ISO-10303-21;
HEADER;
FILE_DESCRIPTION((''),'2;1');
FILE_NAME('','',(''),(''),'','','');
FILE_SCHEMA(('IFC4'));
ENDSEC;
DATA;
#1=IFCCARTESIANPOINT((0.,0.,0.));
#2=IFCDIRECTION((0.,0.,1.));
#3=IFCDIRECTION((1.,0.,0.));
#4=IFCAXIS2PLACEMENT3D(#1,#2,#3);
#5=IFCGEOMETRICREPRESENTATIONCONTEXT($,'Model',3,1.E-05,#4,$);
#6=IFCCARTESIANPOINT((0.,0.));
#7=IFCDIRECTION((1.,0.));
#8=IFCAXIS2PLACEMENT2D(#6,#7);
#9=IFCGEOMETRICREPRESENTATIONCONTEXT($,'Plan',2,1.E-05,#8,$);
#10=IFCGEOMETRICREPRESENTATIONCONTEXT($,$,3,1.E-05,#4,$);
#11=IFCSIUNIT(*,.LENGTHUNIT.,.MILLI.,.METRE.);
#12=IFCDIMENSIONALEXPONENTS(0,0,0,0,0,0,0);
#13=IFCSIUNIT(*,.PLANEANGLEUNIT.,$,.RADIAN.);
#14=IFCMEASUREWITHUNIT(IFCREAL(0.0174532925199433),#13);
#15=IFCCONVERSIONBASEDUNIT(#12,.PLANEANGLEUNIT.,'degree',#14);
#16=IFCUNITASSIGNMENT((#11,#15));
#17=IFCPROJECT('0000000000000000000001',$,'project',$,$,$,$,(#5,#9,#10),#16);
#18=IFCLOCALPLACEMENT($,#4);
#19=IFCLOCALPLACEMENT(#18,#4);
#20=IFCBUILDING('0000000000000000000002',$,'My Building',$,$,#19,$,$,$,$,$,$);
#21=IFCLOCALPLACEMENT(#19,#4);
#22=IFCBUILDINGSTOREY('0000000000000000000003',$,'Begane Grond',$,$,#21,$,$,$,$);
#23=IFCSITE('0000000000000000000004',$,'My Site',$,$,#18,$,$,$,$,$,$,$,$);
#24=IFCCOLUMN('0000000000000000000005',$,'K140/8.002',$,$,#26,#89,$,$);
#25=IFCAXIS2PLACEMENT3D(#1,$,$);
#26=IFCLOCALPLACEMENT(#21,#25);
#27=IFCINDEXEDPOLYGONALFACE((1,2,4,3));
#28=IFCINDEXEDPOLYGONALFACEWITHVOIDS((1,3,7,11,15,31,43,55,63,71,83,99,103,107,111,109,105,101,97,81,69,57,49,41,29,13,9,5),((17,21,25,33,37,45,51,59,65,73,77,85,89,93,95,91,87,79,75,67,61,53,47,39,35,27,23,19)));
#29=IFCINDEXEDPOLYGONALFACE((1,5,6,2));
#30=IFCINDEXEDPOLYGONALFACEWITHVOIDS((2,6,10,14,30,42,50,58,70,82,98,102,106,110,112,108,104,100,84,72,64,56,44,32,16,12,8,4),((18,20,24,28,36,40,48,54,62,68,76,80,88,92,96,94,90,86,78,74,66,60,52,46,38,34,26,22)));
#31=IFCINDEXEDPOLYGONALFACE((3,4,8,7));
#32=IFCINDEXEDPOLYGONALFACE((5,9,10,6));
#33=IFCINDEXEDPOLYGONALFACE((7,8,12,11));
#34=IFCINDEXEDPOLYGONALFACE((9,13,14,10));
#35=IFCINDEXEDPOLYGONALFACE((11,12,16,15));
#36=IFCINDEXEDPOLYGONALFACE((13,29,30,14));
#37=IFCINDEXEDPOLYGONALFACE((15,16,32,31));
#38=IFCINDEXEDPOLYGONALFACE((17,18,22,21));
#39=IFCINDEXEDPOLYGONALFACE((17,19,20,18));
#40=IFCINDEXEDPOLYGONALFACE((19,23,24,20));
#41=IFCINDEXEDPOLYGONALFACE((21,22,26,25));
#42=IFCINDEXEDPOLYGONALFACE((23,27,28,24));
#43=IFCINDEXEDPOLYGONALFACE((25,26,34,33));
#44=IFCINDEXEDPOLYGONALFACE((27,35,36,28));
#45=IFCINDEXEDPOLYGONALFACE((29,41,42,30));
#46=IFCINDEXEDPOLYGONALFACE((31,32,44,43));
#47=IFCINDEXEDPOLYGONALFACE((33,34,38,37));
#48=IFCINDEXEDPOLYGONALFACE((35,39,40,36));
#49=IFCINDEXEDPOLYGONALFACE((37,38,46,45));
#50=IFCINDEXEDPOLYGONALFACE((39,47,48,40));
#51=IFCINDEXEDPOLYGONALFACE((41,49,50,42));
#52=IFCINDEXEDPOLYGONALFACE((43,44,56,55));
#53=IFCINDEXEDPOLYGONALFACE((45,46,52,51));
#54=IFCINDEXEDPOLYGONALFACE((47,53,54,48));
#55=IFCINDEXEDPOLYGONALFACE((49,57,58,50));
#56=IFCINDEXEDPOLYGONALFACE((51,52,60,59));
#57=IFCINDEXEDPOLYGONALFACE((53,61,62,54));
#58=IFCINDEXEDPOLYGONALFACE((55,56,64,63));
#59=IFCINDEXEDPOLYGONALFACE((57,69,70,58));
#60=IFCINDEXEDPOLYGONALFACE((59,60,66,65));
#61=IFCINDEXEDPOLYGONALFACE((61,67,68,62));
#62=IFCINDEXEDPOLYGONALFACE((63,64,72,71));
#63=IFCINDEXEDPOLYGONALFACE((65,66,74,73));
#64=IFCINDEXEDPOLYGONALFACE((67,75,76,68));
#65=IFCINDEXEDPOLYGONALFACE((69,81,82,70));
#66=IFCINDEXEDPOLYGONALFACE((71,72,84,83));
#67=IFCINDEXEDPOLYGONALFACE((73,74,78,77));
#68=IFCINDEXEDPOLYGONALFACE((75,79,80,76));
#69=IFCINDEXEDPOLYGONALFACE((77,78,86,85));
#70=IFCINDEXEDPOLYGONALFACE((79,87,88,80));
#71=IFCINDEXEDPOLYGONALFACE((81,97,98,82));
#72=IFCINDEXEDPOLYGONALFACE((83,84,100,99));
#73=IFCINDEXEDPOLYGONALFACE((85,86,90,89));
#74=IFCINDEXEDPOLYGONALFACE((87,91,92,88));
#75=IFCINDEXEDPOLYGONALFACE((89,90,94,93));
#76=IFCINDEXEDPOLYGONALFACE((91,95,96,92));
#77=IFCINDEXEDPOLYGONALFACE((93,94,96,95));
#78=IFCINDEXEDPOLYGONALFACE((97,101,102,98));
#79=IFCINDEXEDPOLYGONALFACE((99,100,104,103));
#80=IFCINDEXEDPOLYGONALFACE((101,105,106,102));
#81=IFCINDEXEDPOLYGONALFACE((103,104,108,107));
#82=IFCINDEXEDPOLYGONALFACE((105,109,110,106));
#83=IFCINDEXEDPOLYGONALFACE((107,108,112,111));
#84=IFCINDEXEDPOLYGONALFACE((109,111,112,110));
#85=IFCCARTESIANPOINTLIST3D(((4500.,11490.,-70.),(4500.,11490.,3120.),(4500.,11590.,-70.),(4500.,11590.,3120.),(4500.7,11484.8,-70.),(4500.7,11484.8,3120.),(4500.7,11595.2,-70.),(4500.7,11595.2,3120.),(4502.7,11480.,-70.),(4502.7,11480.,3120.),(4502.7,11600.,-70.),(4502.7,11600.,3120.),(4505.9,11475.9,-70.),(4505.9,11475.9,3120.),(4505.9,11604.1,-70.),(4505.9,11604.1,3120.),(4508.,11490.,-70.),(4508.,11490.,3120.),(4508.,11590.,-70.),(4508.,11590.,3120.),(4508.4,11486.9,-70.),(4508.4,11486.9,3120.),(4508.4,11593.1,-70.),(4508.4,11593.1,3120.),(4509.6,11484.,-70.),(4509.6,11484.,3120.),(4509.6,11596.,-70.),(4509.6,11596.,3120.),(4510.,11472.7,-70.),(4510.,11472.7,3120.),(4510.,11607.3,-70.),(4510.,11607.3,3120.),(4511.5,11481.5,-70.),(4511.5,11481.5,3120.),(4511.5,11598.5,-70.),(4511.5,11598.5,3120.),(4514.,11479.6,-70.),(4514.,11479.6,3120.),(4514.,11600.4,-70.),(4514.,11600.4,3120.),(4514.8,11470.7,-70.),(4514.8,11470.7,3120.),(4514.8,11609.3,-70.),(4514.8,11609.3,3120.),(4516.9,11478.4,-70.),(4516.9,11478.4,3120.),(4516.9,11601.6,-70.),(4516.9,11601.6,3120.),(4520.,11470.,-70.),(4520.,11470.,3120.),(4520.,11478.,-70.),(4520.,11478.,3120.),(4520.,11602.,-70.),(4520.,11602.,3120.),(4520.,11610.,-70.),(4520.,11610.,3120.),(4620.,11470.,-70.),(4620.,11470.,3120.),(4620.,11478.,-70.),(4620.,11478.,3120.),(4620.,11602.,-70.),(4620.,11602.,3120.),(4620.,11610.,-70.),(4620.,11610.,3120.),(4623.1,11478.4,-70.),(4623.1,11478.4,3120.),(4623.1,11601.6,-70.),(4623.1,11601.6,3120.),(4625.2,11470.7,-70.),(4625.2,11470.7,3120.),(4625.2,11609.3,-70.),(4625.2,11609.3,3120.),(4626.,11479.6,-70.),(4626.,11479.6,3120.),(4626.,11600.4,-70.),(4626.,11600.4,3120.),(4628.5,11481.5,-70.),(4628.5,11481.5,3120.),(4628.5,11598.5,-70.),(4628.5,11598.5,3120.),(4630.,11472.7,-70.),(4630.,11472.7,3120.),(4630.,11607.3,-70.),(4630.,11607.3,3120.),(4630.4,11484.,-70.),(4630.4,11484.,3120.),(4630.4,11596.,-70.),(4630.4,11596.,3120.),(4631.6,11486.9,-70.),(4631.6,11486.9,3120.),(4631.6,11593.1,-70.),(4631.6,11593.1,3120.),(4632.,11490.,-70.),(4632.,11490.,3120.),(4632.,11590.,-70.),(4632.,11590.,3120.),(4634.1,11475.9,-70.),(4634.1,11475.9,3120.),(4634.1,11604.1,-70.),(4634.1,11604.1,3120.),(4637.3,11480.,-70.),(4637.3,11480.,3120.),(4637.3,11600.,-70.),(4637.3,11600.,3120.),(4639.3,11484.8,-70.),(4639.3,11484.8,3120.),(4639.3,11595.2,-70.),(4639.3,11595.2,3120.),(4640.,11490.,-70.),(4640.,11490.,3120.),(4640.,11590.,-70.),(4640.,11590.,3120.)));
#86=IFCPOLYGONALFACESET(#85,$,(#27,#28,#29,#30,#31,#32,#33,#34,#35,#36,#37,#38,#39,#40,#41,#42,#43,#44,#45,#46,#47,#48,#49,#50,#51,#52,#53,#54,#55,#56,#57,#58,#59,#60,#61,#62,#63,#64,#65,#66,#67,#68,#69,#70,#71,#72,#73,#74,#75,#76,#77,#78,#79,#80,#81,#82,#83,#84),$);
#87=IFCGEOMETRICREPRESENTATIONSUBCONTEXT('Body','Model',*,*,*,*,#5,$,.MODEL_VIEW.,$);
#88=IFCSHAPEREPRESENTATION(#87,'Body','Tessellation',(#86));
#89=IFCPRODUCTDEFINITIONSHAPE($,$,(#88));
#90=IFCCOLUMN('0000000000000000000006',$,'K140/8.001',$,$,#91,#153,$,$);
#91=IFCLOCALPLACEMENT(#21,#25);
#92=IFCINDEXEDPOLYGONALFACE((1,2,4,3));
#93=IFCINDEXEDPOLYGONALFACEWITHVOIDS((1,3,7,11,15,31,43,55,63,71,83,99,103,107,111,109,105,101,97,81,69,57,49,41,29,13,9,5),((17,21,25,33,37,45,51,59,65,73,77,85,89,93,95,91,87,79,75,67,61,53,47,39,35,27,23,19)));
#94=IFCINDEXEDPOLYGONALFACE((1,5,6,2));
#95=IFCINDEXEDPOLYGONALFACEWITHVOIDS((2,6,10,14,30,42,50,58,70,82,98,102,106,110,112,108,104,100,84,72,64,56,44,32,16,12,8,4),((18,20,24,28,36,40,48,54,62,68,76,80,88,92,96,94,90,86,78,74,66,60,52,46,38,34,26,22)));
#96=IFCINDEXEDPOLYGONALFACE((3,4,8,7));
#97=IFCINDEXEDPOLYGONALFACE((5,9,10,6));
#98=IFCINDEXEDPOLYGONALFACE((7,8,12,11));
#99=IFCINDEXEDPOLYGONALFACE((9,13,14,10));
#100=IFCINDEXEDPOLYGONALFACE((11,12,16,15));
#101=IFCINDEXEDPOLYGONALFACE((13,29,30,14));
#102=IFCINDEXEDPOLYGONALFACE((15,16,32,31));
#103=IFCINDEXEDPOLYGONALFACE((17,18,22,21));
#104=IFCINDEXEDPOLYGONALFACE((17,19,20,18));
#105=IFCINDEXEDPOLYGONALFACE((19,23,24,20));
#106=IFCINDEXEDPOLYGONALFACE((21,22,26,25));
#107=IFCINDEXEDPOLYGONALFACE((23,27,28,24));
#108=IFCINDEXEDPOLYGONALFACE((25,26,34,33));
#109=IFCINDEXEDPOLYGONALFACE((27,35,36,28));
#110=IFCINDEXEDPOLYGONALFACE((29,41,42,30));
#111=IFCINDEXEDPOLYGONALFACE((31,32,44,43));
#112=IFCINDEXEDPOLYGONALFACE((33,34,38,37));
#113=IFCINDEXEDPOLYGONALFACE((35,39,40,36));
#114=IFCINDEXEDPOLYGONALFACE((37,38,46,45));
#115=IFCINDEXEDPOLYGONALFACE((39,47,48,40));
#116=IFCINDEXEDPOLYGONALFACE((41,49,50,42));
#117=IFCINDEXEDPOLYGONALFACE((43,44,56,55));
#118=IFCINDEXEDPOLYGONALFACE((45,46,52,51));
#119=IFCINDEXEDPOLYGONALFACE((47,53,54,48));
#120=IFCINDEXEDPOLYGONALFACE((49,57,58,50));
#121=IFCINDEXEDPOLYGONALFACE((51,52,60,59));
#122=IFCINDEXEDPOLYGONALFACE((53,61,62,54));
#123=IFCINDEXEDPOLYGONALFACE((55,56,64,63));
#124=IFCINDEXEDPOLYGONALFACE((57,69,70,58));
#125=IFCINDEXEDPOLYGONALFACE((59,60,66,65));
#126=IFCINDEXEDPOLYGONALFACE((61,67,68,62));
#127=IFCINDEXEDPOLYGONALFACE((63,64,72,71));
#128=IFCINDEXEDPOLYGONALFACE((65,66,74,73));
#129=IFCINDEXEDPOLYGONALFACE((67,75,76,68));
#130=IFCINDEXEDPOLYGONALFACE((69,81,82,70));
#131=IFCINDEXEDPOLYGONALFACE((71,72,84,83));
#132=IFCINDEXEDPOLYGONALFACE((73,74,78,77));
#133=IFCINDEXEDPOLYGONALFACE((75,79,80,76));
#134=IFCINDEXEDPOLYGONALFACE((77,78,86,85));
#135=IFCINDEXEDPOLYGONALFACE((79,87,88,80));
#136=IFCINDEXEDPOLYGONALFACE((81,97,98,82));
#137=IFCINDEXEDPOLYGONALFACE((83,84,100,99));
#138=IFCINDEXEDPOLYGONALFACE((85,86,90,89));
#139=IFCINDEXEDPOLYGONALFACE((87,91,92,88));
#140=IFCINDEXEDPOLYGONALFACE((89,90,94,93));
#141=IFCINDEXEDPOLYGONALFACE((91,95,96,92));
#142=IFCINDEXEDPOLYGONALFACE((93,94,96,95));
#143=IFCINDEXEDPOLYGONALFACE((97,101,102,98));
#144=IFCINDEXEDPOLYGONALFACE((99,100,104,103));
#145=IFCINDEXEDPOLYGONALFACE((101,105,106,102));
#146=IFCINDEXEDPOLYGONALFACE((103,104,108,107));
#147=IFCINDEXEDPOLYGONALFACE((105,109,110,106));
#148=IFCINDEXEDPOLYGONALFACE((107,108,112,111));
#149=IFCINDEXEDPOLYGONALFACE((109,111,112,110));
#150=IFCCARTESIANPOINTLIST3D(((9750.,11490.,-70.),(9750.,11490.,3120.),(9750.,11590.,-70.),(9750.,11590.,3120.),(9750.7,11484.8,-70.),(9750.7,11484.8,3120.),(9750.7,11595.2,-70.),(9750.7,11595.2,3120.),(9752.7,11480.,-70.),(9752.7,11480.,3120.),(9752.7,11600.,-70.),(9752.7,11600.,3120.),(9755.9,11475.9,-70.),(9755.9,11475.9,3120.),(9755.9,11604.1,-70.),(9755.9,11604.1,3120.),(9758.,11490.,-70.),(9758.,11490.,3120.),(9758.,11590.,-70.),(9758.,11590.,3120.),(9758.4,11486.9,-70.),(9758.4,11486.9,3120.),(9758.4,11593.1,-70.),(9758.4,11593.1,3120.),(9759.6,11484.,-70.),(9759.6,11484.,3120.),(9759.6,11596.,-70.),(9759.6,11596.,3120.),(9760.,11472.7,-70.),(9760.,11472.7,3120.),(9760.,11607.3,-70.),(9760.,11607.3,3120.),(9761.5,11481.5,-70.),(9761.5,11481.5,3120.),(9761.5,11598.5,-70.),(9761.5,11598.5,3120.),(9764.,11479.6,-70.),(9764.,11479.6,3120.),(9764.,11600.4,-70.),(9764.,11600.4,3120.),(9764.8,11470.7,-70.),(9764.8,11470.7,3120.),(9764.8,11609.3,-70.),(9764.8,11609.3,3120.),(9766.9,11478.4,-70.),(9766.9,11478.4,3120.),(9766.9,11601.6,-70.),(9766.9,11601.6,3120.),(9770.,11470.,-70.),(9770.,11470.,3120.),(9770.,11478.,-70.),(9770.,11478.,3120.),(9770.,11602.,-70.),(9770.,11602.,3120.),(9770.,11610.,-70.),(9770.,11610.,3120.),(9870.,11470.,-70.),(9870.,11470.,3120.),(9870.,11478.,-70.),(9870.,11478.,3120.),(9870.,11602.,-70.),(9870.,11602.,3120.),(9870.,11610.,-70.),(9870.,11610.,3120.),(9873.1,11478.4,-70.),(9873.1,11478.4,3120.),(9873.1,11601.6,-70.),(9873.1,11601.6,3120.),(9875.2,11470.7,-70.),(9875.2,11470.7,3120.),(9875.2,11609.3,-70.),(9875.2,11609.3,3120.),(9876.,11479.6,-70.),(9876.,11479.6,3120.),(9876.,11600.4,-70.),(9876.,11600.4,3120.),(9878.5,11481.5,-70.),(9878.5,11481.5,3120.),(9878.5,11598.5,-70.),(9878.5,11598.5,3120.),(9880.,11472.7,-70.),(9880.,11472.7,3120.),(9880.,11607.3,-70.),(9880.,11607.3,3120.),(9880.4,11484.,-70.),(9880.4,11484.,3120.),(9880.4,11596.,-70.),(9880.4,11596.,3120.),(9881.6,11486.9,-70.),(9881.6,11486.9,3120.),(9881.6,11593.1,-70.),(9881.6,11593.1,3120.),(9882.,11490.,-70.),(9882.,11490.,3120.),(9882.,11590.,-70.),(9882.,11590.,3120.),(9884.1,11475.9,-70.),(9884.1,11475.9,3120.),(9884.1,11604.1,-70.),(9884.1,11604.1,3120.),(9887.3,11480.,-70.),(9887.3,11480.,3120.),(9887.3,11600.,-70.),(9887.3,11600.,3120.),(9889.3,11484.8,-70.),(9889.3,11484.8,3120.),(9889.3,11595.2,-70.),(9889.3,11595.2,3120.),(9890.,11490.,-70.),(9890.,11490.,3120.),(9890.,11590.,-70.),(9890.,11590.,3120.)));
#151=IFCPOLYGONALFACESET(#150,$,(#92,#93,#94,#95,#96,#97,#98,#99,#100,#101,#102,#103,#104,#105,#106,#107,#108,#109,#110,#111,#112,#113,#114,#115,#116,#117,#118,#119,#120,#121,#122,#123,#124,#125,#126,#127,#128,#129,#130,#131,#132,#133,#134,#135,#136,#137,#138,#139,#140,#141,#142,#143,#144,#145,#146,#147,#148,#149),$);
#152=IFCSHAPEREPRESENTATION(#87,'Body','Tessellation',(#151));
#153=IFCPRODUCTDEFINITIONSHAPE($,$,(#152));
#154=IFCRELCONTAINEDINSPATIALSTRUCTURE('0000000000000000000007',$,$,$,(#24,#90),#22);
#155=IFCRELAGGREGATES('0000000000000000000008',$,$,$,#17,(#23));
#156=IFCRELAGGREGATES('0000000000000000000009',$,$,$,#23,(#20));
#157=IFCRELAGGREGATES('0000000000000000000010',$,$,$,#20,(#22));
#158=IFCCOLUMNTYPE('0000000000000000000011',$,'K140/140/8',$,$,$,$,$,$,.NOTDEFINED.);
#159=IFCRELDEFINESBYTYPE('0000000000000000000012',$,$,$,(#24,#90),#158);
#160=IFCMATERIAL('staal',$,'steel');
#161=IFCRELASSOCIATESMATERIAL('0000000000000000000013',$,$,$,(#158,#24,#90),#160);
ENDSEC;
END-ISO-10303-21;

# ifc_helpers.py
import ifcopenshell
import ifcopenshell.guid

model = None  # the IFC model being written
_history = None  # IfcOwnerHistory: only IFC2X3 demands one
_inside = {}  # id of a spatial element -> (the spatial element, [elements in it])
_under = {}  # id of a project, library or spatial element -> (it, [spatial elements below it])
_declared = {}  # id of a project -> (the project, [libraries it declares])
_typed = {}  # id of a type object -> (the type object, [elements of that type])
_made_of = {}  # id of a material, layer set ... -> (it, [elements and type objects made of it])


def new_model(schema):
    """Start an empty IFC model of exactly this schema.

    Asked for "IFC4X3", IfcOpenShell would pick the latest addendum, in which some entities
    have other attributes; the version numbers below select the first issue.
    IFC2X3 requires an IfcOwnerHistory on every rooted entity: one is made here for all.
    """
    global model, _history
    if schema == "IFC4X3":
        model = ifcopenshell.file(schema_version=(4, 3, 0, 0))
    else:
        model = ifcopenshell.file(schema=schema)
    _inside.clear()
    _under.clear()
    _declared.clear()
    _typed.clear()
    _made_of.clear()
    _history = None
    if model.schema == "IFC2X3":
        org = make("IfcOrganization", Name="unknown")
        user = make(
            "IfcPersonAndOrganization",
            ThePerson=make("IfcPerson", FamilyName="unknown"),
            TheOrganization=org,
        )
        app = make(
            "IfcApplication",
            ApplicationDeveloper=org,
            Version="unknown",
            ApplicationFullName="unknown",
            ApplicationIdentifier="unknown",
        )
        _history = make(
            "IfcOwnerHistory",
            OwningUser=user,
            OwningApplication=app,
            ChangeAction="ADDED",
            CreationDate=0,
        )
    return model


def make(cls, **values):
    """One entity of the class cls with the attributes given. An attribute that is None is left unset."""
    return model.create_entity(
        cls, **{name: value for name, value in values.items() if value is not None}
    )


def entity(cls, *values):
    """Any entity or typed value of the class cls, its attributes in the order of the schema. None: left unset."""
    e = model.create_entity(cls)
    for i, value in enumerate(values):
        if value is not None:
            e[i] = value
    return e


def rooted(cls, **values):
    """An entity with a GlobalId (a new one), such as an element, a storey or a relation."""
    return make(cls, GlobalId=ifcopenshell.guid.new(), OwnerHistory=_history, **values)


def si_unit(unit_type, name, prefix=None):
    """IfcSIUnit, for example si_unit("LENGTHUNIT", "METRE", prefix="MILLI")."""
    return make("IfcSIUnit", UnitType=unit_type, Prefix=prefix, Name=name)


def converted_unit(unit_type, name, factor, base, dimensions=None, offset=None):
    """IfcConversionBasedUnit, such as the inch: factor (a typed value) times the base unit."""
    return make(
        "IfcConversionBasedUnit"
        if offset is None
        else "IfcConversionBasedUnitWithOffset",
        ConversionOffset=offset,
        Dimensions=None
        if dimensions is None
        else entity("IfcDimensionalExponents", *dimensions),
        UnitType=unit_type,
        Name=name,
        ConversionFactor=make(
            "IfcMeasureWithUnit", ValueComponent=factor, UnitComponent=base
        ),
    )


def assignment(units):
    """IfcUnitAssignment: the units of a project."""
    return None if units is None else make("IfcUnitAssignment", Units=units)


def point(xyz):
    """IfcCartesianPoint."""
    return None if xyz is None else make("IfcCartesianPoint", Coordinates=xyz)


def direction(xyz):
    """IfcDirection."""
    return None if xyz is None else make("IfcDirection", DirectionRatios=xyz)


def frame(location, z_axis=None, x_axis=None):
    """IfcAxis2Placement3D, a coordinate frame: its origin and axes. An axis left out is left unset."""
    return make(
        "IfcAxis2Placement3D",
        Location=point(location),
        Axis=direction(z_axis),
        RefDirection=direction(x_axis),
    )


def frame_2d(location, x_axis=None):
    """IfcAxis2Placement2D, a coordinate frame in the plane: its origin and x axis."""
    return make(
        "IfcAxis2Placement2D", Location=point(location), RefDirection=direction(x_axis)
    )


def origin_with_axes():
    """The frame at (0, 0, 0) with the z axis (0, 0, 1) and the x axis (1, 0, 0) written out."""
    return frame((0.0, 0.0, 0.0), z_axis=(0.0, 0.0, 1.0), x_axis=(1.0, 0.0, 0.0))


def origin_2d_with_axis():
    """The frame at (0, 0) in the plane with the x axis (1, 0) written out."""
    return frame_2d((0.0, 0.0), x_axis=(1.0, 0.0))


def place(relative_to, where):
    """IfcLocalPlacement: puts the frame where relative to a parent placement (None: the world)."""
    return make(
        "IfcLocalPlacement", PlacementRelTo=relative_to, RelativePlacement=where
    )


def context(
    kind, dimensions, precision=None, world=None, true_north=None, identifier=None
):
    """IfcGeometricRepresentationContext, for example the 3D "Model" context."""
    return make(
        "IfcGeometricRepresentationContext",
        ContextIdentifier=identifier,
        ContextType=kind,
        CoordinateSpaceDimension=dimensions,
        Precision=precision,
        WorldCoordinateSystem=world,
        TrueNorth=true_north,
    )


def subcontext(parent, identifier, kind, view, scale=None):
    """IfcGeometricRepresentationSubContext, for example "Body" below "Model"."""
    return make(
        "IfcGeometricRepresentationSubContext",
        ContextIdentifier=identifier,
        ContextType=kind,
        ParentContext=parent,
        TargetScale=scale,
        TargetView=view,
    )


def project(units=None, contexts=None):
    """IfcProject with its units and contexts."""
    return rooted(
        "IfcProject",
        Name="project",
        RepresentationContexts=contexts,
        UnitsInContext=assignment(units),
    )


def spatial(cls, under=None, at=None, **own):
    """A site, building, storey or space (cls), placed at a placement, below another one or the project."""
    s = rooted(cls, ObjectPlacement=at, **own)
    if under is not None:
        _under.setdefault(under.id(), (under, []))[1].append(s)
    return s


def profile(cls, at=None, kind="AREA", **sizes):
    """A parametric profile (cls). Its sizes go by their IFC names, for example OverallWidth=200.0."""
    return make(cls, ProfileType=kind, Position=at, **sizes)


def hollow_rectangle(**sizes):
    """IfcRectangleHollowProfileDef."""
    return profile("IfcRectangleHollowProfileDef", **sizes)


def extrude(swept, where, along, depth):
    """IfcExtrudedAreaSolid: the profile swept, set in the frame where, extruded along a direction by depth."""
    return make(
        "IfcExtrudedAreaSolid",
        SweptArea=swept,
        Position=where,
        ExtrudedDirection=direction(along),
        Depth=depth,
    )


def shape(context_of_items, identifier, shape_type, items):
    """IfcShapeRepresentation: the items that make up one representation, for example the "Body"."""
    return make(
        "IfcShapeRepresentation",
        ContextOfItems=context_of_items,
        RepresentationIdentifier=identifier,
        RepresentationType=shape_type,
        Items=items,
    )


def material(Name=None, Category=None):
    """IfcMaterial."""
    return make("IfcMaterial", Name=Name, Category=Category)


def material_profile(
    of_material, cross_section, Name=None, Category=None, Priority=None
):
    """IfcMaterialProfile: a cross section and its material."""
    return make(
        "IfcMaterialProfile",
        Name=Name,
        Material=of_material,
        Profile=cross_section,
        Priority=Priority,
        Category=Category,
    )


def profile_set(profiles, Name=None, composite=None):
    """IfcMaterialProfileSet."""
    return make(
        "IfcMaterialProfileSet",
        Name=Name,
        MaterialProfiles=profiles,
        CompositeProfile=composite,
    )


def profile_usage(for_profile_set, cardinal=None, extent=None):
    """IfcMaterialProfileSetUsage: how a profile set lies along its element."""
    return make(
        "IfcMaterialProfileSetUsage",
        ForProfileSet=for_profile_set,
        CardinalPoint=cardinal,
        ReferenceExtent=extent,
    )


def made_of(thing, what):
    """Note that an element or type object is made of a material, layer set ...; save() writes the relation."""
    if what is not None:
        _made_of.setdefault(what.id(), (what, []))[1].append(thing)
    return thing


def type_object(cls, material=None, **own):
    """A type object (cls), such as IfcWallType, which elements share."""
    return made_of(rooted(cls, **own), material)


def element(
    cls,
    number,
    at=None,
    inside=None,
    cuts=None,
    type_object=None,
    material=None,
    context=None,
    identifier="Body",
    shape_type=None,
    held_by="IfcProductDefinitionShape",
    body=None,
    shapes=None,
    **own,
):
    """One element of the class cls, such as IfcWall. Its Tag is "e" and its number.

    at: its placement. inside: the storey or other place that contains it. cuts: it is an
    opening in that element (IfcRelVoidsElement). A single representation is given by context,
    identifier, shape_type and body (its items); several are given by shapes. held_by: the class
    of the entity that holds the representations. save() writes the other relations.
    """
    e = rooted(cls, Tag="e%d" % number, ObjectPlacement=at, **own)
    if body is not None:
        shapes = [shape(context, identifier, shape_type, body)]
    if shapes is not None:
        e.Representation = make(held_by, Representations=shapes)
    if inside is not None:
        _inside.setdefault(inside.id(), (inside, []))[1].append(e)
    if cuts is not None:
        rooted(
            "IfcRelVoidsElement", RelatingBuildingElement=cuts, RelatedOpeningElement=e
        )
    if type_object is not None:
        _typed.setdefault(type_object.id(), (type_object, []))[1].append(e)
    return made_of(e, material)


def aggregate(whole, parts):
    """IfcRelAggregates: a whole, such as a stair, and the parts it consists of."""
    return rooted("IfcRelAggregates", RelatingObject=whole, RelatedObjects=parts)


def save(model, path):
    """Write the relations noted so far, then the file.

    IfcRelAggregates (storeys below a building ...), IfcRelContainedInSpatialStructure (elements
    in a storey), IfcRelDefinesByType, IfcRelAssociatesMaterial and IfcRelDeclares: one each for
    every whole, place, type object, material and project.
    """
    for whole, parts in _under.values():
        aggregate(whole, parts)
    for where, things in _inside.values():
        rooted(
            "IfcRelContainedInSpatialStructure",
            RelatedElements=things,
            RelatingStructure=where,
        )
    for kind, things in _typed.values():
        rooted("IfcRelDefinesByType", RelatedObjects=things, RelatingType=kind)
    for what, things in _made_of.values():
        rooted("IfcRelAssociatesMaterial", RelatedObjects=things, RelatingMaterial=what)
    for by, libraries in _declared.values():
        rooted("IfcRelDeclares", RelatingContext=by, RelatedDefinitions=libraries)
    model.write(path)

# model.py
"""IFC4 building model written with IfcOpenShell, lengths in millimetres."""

from ifc_helpers import new_model, entity, si_unit, converted_unit, frame, origin_with_axes, origin_2d_with_axis, place, context, subcontext, project, spatial, hollow_rectangle, extrude, material, material_profile, profile_set, profile_usage, type_object, element, save


model = new_model("IFC4")

# Units and contexts
model_context = context("Model", 3, precision=1e-05, world=origin_with_axes())
plan_context = context("Plan", 2, precision=1e-05, world=origin_2d_with_axis())
context_of_model = context(None, 3, precision=1e-05, world=origin_with_axes())
body_context = subcontext(model_context, "Body", "Model", "MODEL_VIEW")
ifc_project = project(units=[si_unit("LENGTHUNIT", "METRE", prefix="MILLI"), converted_unit("PLANEANGLEUNIT", "degree", entity("IfcReal", 0.0174532925199433), si_unit("PLANEANGLEUNIT", "RADIAN"), dimensions=[0, 0, 0, 0, 0, 0, 0])], contexts=[model_context, plan_context, context_of_model])

# Site, building, storey
site_placement = place(None, origin_with_axes())
site = spatial("IfcSite", under=ifc_project, at=site_placement, Name="My Site")
building_placement = place(site_placement, origin_with_axes())
building = spatial("IfcBuilding", under=site, at=building_placement, Name="My Building")
storey_placement = place(building_placement, origin_with_axes())
storey = spatial("IfcBuildingStorey", under=building, at=storey_placement, Name="Begane Grond")

# Columns
ifc_material = material(Name="staal", Category="steel")
ifc_material_profile_1 = material_profile(ifc_material, hollow_rectangle(XDim=140.0, YDim=140.0, WallThickness=8.0, InnerFilletRadius=12.0, OuterFilletRadius=20.0))
ifc_profile_set_1 = profile_set([ifc_material_profile_1], Name="K140/140/8")
ifc_profile_usage_1 = profile_usage(ifc_profile_set_1, cardinal=5)
column_type_1 = type_object("IfcColumnType", Name="K140/140/8", PredefinedType="NOTDEFINED", material=ifc_profile_set_1)
column_1_placement = place(storey_placement, frame((4570.0, 11540.0, -70.0), z_axis=(0.0, 0.0, 1.0), x_axis=(1.0, 0.0, 0.0)))
element("IfcColumn", 1, at=column_1_placement, inside=storey, type_object=column_type_1, material=ifc_profile_usage_1, Name="K140/8.002", context=body_context, shape_type="SweptSolid", body=[
    extrude(hollow_rectangle(XDim=140.0, YDim=140.0, WallThickness=8.0, InnerFilletRadius=12.0, OuterFilletRadius=20.0), origin_with_axes(), (0.0, 0.0, 1.0), 3190.0),
])
ifc_profile_usage_2 = profile_usage(ifc_profile_set_1, cardinal=5)
column_2_placement = place(storey_placement, frame((9820.0, 11540.0, -70.0), z_axis=(0.0, 0.0, 1.0), x_axis=(1.0, 0.0, 0.0)))
element("IfcColumn", 2, at=column_2_placement, inside=storey, type_object=column_type_1, material=ifc_profile_usage_2, Name="K140/8.001", context=body_context, shape_type="SweptSolid", body=[
    extrude(hollow_rectangle(XDim=140.0, YDim=140.0, WallThickness=8.0, InnerFilletRadius=12.0, OuterFilletRadius=20.0), origin_with_axes(), (0.0, 0.0, 1.0), 3190.0),
])

save(model, "model.ifc")
